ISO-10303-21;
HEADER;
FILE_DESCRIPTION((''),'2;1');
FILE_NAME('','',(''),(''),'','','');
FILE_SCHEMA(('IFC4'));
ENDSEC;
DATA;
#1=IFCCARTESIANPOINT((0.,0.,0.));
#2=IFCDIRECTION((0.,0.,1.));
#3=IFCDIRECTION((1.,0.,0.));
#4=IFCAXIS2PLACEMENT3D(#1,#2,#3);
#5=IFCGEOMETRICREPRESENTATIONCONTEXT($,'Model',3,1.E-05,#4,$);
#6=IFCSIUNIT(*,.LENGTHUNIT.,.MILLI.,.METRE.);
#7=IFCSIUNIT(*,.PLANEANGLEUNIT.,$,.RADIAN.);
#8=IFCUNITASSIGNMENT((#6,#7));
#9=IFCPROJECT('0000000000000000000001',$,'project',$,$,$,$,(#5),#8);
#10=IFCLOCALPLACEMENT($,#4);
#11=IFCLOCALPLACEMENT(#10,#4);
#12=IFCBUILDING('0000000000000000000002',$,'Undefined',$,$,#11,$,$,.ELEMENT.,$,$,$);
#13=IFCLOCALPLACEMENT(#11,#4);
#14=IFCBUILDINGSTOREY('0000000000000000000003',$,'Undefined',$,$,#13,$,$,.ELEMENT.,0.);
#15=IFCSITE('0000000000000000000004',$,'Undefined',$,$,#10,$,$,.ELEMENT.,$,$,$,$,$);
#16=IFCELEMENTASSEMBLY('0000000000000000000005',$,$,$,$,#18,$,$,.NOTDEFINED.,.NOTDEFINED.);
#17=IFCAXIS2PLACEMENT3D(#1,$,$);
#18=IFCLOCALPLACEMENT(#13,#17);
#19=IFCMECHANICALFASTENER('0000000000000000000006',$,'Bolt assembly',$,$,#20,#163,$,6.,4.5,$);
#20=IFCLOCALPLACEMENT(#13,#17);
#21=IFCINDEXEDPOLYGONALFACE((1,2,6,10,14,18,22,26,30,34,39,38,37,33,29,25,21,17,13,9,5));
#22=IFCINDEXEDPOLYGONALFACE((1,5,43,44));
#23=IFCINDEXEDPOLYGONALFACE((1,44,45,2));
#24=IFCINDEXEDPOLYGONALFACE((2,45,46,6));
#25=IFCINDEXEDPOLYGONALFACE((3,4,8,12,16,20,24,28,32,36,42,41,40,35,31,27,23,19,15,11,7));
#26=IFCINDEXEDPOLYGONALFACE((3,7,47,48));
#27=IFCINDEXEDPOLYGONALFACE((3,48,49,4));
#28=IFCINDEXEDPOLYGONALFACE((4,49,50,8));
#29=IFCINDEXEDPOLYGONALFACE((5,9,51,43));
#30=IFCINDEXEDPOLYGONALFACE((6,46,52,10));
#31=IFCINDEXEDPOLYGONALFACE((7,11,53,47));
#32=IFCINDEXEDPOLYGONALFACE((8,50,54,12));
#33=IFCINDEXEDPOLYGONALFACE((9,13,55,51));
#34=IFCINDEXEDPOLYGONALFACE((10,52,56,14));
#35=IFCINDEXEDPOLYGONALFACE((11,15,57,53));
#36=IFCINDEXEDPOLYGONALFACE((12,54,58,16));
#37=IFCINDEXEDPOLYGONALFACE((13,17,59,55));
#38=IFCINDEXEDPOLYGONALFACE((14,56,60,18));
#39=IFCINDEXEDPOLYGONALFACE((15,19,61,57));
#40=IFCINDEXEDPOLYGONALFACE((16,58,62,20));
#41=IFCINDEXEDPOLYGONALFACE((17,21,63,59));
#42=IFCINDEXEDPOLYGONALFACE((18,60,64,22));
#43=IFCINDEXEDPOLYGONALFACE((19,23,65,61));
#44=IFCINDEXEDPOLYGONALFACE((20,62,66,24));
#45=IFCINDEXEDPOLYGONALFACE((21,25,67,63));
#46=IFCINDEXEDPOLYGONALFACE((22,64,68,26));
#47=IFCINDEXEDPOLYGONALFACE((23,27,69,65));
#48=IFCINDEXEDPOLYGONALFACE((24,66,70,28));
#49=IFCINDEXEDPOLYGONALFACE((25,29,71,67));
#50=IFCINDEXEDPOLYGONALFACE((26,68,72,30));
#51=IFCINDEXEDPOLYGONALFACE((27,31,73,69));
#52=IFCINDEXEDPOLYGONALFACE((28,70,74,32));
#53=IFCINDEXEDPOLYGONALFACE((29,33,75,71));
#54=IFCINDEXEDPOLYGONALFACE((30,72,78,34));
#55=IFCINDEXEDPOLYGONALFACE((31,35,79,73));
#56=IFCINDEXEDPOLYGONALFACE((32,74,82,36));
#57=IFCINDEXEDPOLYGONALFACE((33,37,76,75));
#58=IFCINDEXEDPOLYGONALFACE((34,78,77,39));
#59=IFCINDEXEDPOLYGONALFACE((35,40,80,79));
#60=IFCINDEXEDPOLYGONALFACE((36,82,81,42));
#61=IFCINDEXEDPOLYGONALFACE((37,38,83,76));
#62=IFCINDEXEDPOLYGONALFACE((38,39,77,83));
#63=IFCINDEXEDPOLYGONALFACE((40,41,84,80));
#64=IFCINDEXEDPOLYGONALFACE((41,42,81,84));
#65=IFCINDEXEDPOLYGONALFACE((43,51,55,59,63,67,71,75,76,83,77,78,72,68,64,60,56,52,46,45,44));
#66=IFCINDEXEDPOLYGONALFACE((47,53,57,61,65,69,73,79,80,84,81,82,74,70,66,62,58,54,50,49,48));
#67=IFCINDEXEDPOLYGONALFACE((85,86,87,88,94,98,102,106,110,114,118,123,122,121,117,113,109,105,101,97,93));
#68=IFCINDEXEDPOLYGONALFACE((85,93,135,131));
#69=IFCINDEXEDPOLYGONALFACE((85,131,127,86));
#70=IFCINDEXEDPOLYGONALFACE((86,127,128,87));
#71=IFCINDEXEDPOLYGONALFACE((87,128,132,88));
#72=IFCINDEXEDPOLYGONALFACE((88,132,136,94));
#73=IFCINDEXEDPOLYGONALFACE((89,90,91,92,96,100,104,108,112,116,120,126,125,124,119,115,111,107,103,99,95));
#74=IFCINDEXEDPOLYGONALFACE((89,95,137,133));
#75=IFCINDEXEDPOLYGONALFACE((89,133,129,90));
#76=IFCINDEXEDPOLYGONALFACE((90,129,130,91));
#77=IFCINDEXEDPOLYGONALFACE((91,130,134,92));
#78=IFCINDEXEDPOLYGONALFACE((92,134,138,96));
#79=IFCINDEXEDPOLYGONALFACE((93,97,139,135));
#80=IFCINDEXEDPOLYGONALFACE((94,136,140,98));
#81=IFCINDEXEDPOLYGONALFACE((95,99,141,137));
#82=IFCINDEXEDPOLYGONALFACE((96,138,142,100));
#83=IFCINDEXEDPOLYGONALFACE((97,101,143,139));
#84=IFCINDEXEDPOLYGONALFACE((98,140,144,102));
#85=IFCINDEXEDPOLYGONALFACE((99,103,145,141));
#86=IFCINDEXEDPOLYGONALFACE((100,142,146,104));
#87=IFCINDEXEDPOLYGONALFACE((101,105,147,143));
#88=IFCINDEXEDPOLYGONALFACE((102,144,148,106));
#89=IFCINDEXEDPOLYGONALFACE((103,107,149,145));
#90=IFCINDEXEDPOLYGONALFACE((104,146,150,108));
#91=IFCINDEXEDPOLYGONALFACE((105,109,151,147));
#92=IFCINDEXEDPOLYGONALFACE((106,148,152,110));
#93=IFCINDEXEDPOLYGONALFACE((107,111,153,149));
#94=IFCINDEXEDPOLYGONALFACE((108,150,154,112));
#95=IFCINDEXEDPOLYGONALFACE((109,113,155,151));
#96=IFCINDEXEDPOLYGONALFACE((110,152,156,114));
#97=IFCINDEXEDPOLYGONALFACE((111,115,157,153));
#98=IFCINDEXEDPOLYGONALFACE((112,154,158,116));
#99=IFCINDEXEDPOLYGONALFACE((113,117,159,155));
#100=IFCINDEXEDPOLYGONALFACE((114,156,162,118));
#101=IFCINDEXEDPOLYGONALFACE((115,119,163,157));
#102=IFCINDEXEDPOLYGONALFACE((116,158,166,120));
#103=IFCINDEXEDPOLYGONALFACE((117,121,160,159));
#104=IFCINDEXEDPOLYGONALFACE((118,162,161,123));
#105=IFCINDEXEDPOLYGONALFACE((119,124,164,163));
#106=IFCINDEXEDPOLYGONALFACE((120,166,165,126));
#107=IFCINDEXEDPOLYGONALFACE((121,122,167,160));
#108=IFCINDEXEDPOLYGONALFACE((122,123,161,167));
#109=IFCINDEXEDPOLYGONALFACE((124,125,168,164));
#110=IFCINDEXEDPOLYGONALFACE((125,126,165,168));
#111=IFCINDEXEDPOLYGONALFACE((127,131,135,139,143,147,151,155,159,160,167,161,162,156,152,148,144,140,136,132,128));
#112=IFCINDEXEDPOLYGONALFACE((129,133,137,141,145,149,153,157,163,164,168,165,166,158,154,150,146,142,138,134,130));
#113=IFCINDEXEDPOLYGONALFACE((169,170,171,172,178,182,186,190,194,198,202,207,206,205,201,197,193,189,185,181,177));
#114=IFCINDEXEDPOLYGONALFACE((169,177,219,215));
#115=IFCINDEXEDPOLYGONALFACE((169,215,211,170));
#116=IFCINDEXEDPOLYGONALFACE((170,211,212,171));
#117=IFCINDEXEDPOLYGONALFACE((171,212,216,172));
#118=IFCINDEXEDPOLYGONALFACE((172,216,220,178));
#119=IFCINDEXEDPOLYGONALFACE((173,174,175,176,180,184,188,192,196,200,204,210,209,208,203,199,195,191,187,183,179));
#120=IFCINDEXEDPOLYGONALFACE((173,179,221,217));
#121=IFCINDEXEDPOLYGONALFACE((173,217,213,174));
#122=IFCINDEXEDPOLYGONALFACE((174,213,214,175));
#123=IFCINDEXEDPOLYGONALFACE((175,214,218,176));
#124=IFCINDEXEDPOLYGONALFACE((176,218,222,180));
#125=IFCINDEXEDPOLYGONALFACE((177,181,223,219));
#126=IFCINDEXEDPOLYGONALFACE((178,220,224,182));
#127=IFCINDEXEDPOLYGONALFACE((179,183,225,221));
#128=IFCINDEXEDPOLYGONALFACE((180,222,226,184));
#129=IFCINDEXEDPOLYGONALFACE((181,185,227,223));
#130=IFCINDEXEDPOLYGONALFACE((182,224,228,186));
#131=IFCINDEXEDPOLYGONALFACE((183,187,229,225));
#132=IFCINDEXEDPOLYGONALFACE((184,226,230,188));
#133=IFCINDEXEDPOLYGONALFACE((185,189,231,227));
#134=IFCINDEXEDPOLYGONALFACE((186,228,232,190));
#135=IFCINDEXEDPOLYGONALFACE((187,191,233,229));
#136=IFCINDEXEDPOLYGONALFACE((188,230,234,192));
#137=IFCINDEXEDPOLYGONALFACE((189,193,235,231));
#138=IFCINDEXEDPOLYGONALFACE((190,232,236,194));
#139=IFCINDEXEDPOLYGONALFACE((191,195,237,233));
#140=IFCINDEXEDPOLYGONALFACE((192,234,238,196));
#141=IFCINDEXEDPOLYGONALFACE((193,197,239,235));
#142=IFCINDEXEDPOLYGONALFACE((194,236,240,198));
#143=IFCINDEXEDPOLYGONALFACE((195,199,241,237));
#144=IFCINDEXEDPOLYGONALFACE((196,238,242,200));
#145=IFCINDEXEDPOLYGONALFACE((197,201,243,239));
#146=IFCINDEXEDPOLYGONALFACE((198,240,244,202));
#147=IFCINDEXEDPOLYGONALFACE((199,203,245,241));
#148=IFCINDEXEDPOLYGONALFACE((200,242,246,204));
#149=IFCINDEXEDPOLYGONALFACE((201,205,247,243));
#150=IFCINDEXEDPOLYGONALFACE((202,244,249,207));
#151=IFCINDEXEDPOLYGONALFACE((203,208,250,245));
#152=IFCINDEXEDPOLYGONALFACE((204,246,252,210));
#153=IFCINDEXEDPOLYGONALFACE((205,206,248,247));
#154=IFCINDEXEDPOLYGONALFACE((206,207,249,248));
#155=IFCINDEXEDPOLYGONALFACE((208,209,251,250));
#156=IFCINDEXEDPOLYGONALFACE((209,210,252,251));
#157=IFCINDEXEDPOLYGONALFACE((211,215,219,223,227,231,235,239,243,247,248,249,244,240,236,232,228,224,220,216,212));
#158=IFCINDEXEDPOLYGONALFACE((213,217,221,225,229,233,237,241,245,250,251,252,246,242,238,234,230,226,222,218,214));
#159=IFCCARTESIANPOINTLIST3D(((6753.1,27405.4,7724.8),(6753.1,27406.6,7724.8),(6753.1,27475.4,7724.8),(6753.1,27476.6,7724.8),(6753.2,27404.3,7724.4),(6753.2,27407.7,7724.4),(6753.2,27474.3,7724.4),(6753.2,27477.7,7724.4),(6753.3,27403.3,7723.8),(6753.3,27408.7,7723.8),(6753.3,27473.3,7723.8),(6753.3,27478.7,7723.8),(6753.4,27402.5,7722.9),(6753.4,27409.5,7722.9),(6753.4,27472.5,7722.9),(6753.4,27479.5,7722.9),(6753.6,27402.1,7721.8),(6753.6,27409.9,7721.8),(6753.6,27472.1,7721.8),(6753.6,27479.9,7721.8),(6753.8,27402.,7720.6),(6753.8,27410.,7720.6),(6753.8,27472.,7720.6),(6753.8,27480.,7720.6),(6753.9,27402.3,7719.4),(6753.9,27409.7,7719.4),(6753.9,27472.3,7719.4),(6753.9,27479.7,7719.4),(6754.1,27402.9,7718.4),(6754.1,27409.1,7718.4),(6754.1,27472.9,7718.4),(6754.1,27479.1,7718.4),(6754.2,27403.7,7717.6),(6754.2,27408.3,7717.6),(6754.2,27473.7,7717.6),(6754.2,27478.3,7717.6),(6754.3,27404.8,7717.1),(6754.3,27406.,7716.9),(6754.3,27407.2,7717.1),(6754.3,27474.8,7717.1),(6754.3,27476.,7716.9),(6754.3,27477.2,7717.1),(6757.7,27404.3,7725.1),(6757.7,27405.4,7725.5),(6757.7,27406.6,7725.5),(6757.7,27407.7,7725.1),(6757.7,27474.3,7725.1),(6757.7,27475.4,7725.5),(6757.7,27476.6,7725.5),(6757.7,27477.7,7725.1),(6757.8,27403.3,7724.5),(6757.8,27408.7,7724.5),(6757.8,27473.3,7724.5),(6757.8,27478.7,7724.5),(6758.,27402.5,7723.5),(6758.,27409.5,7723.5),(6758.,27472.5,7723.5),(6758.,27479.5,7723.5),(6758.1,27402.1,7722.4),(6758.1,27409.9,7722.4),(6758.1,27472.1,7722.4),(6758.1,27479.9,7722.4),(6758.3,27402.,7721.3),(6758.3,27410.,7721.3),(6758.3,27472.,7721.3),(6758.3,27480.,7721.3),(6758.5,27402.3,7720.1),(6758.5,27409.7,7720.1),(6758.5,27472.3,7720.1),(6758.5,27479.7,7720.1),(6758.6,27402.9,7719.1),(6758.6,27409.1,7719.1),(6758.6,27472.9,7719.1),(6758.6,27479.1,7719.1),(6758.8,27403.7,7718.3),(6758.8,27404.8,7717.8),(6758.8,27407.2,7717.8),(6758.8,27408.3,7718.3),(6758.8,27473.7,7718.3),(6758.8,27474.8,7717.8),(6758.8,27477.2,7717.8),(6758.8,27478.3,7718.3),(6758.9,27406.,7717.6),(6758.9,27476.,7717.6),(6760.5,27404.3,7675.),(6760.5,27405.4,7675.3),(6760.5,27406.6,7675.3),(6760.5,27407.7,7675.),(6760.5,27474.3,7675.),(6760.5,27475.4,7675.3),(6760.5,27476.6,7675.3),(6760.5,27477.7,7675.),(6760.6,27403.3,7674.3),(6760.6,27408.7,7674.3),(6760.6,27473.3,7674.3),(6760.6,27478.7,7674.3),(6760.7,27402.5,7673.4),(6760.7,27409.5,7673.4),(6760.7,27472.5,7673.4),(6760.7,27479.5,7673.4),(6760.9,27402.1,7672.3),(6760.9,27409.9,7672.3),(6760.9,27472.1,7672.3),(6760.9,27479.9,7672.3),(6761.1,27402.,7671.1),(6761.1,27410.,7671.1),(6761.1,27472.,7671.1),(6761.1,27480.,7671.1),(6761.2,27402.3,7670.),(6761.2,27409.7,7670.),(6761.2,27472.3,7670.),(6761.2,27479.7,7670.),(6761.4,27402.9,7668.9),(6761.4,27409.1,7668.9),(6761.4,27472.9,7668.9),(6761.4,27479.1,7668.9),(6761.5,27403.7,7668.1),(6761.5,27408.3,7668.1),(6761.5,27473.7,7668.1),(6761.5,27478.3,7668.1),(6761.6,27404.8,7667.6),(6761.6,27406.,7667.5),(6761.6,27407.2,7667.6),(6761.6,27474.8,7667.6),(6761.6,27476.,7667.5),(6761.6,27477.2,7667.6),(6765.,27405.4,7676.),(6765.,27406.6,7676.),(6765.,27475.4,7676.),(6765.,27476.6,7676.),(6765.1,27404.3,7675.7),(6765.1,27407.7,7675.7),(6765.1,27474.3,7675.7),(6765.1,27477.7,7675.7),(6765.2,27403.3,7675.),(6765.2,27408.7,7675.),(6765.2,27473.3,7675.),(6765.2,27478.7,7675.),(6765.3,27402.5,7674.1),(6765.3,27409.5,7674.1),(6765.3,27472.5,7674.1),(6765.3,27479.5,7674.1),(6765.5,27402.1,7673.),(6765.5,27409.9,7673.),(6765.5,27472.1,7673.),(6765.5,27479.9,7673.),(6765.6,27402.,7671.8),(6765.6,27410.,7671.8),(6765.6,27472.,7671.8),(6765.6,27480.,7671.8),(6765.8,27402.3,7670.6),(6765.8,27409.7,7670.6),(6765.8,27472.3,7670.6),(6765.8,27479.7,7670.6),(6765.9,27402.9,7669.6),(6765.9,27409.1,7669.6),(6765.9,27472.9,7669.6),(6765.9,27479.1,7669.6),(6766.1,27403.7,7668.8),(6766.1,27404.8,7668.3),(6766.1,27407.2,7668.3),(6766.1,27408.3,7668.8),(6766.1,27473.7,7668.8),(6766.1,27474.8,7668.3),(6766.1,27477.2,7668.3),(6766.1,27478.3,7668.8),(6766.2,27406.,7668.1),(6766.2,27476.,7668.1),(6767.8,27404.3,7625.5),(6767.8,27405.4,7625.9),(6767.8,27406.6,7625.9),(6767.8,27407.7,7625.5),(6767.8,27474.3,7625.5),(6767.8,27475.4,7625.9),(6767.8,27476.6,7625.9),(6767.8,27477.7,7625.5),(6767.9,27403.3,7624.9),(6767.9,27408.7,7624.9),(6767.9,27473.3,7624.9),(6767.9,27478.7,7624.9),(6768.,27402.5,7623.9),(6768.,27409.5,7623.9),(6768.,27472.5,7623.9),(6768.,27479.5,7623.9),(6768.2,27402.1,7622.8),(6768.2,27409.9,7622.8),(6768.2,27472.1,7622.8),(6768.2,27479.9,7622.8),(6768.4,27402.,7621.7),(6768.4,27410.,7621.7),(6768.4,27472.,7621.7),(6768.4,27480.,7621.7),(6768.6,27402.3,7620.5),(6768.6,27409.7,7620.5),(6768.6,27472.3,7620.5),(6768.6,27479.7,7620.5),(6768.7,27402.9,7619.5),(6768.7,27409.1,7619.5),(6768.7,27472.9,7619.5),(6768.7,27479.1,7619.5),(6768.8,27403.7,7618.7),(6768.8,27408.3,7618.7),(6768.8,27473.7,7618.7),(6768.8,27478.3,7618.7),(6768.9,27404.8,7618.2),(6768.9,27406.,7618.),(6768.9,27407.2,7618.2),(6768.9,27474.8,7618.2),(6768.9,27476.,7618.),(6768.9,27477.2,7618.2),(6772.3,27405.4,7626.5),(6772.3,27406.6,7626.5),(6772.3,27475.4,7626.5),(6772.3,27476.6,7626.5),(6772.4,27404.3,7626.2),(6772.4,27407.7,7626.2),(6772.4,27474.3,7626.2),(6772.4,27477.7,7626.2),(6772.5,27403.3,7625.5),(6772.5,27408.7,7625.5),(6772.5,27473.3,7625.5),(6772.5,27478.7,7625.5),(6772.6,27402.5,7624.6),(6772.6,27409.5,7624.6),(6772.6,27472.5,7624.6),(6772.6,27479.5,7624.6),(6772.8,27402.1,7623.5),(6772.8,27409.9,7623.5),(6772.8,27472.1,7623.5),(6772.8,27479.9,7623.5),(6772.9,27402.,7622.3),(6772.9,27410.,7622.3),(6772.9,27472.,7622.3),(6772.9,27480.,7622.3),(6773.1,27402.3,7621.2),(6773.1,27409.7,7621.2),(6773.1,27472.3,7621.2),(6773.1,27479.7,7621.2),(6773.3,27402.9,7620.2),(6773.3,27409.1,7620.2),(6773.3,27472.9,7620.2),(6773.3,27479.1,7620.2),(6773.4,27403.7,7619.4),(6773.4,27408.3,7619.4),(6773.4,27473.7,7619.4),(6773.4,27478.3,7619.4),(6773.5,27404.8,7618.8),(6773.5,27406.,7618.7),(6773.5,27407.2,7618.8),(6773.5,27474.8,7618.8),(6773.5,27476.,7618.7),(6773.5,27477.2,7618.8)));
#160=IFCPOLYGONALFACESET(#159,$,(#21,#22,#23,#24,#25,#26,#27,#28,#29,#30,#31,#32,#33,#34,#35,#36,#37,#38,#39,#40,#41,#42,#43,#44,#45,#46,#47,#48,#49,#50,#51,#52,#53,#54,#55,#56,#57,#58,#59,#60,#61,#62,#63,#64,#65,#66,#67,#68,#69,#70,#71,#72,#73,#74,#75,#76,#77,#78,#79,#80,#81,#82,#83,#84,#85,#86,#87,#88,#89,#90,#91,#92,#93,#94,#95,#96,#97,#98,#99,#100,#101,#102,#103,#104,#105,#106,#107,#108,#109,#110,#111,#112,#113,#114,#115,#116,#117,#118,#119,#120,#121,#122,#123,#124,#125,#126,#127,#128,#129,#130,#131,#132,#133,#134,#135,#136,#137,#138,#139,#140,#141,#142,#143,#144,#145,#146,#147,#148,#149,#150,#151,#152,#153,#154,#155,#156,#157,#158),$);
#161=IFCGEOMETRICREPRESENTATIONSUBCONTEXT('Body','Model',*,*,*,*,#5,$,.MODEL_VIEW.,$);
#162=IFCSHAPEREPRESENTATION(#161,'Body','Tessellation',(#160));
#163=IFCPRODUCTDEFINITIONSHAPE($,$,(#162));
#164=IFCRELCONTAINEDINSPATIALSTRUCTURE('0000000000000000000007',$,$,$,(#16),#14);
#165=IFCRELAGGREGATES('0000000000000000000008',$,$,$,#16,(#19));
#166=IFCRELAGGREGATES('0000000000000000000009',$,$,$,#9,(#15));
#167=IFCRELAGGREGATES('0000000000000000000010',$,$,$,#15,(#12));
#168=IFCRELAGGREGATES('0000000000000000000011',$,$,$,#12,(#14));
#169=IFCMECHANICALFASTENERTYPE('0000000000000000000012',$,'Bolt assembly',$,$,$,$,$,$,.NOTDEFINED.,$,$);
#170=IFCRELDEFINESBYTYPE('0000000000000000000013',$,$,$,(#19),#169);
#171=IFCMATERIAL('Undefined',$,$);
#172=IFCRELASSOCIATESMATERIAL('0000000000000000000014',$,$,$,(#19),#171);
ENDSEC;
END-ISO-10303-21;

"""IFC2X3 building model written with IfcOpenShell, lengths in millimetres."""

from ifc_helpers import new_model, si_unit, frame, origin_with_axes, origin_2d_with_axis, place, context, subcontext, project, spatial, circle, extrude, source, transform, mapped, material, type_object, element, aggregate, save


model = new_model("IFC2X3")

# Units and contexts
model_context = context("Model", 3, precision=1e-05, world=origin_with_axes())
body_context = subcontext(model_context, "Body", "Model", "MODEL_VIEW")
ifc_project = project(units=[si_unit("LENGTHUNIT", "METRE", prefix="MILLI"), si_unit("PLANEANGLEUNIT", "RADIAN")], contexts=[model_context])

# Site, building, storey
site_placement = place(None, origin_with_axes())
site = spatial("IfcSite", under=ifc_project, at=site_placement, Name="Undefined", CompositionType="ELEMENT")
building_placement = place(site_placement, origin_with_axes())
building = spatial("IfcBuilding", under=site, at=building_placement, Name="Undefined", CompositionType="ELEMENT")
storey_placement = place(building_placement, origin_with_axes())
storey = spatial("IfcBuildingStorey", under=building, at=storey_placement, Name="Undefined", CompositionType="ELEMENT", Elevation=0.0)

# Element assembly
assembly_1_placement = place(storey_placement, origin_with_axes())
assembly_1 = element("IfcElementAssembly", 1, at=assembly_1_placement, inside=storey, AssemblyPlace="NOTDEFINED", PredefinedType="NOTDEFINED")

# Mechanical fastener
ifc_material_1 = material(Name="Undefined")
mechanical_fastener_type = type_object("IfcMechanicalFastenerType", Name="Bolt assembly")
shared_shape_1 = source(origin_with_axes(), body_context, "Body", "SweptSolid", [
    extrude(circle(Radius=4.0, at=origin_2d_with_axis()), frame((0.0, 0.0, 0.0), z_axis=(0.0, 1.0, 0.0), x_axis=(1.0, 0.0, 0.0)), (0.0, 0.0, 1.0), 4.6),
])
mechanical_fastener_1_placement = place(assembly_1_placement, frame((6753.7, 27441.0, 7720.9), z_axis=(0.0, -1.0, 0.0), x_axis=(0.146203, 0.0, -0.989255)))
mechanical_fastener_1 = element("IfcMechanicalFastener", 2, at=mechanical_fastener_1_placement, type_object=mechanical_fastener_type, material=ifc_material_1, Name="Bolt assembly", NominalDiameter=6.0, NominalLength=4.5, context=body_context, shape_type="MappedRepresentation", body=[
    mapped(shared_shape_1, transform((0.0, 0.0, -35.0))),
    mapped(shared_shape_1, transform((50.0, 0.0, -35.0))),
    mapped(shared_shape_1, transform((100.0, 0.0, -35.0))),
    mapped(shared_shape_1, transform((0.0, 0.0, 35.0))),
    mapped(shared_shape_1, transform((50.0, 0.0, 35.0))),
    mapped(shared_shape_1, transform((100.0, 0.0, 35.0))),
])

aggregate(assembly_1, [mechanical_fastener_1])

save(model, "model.ifc")
